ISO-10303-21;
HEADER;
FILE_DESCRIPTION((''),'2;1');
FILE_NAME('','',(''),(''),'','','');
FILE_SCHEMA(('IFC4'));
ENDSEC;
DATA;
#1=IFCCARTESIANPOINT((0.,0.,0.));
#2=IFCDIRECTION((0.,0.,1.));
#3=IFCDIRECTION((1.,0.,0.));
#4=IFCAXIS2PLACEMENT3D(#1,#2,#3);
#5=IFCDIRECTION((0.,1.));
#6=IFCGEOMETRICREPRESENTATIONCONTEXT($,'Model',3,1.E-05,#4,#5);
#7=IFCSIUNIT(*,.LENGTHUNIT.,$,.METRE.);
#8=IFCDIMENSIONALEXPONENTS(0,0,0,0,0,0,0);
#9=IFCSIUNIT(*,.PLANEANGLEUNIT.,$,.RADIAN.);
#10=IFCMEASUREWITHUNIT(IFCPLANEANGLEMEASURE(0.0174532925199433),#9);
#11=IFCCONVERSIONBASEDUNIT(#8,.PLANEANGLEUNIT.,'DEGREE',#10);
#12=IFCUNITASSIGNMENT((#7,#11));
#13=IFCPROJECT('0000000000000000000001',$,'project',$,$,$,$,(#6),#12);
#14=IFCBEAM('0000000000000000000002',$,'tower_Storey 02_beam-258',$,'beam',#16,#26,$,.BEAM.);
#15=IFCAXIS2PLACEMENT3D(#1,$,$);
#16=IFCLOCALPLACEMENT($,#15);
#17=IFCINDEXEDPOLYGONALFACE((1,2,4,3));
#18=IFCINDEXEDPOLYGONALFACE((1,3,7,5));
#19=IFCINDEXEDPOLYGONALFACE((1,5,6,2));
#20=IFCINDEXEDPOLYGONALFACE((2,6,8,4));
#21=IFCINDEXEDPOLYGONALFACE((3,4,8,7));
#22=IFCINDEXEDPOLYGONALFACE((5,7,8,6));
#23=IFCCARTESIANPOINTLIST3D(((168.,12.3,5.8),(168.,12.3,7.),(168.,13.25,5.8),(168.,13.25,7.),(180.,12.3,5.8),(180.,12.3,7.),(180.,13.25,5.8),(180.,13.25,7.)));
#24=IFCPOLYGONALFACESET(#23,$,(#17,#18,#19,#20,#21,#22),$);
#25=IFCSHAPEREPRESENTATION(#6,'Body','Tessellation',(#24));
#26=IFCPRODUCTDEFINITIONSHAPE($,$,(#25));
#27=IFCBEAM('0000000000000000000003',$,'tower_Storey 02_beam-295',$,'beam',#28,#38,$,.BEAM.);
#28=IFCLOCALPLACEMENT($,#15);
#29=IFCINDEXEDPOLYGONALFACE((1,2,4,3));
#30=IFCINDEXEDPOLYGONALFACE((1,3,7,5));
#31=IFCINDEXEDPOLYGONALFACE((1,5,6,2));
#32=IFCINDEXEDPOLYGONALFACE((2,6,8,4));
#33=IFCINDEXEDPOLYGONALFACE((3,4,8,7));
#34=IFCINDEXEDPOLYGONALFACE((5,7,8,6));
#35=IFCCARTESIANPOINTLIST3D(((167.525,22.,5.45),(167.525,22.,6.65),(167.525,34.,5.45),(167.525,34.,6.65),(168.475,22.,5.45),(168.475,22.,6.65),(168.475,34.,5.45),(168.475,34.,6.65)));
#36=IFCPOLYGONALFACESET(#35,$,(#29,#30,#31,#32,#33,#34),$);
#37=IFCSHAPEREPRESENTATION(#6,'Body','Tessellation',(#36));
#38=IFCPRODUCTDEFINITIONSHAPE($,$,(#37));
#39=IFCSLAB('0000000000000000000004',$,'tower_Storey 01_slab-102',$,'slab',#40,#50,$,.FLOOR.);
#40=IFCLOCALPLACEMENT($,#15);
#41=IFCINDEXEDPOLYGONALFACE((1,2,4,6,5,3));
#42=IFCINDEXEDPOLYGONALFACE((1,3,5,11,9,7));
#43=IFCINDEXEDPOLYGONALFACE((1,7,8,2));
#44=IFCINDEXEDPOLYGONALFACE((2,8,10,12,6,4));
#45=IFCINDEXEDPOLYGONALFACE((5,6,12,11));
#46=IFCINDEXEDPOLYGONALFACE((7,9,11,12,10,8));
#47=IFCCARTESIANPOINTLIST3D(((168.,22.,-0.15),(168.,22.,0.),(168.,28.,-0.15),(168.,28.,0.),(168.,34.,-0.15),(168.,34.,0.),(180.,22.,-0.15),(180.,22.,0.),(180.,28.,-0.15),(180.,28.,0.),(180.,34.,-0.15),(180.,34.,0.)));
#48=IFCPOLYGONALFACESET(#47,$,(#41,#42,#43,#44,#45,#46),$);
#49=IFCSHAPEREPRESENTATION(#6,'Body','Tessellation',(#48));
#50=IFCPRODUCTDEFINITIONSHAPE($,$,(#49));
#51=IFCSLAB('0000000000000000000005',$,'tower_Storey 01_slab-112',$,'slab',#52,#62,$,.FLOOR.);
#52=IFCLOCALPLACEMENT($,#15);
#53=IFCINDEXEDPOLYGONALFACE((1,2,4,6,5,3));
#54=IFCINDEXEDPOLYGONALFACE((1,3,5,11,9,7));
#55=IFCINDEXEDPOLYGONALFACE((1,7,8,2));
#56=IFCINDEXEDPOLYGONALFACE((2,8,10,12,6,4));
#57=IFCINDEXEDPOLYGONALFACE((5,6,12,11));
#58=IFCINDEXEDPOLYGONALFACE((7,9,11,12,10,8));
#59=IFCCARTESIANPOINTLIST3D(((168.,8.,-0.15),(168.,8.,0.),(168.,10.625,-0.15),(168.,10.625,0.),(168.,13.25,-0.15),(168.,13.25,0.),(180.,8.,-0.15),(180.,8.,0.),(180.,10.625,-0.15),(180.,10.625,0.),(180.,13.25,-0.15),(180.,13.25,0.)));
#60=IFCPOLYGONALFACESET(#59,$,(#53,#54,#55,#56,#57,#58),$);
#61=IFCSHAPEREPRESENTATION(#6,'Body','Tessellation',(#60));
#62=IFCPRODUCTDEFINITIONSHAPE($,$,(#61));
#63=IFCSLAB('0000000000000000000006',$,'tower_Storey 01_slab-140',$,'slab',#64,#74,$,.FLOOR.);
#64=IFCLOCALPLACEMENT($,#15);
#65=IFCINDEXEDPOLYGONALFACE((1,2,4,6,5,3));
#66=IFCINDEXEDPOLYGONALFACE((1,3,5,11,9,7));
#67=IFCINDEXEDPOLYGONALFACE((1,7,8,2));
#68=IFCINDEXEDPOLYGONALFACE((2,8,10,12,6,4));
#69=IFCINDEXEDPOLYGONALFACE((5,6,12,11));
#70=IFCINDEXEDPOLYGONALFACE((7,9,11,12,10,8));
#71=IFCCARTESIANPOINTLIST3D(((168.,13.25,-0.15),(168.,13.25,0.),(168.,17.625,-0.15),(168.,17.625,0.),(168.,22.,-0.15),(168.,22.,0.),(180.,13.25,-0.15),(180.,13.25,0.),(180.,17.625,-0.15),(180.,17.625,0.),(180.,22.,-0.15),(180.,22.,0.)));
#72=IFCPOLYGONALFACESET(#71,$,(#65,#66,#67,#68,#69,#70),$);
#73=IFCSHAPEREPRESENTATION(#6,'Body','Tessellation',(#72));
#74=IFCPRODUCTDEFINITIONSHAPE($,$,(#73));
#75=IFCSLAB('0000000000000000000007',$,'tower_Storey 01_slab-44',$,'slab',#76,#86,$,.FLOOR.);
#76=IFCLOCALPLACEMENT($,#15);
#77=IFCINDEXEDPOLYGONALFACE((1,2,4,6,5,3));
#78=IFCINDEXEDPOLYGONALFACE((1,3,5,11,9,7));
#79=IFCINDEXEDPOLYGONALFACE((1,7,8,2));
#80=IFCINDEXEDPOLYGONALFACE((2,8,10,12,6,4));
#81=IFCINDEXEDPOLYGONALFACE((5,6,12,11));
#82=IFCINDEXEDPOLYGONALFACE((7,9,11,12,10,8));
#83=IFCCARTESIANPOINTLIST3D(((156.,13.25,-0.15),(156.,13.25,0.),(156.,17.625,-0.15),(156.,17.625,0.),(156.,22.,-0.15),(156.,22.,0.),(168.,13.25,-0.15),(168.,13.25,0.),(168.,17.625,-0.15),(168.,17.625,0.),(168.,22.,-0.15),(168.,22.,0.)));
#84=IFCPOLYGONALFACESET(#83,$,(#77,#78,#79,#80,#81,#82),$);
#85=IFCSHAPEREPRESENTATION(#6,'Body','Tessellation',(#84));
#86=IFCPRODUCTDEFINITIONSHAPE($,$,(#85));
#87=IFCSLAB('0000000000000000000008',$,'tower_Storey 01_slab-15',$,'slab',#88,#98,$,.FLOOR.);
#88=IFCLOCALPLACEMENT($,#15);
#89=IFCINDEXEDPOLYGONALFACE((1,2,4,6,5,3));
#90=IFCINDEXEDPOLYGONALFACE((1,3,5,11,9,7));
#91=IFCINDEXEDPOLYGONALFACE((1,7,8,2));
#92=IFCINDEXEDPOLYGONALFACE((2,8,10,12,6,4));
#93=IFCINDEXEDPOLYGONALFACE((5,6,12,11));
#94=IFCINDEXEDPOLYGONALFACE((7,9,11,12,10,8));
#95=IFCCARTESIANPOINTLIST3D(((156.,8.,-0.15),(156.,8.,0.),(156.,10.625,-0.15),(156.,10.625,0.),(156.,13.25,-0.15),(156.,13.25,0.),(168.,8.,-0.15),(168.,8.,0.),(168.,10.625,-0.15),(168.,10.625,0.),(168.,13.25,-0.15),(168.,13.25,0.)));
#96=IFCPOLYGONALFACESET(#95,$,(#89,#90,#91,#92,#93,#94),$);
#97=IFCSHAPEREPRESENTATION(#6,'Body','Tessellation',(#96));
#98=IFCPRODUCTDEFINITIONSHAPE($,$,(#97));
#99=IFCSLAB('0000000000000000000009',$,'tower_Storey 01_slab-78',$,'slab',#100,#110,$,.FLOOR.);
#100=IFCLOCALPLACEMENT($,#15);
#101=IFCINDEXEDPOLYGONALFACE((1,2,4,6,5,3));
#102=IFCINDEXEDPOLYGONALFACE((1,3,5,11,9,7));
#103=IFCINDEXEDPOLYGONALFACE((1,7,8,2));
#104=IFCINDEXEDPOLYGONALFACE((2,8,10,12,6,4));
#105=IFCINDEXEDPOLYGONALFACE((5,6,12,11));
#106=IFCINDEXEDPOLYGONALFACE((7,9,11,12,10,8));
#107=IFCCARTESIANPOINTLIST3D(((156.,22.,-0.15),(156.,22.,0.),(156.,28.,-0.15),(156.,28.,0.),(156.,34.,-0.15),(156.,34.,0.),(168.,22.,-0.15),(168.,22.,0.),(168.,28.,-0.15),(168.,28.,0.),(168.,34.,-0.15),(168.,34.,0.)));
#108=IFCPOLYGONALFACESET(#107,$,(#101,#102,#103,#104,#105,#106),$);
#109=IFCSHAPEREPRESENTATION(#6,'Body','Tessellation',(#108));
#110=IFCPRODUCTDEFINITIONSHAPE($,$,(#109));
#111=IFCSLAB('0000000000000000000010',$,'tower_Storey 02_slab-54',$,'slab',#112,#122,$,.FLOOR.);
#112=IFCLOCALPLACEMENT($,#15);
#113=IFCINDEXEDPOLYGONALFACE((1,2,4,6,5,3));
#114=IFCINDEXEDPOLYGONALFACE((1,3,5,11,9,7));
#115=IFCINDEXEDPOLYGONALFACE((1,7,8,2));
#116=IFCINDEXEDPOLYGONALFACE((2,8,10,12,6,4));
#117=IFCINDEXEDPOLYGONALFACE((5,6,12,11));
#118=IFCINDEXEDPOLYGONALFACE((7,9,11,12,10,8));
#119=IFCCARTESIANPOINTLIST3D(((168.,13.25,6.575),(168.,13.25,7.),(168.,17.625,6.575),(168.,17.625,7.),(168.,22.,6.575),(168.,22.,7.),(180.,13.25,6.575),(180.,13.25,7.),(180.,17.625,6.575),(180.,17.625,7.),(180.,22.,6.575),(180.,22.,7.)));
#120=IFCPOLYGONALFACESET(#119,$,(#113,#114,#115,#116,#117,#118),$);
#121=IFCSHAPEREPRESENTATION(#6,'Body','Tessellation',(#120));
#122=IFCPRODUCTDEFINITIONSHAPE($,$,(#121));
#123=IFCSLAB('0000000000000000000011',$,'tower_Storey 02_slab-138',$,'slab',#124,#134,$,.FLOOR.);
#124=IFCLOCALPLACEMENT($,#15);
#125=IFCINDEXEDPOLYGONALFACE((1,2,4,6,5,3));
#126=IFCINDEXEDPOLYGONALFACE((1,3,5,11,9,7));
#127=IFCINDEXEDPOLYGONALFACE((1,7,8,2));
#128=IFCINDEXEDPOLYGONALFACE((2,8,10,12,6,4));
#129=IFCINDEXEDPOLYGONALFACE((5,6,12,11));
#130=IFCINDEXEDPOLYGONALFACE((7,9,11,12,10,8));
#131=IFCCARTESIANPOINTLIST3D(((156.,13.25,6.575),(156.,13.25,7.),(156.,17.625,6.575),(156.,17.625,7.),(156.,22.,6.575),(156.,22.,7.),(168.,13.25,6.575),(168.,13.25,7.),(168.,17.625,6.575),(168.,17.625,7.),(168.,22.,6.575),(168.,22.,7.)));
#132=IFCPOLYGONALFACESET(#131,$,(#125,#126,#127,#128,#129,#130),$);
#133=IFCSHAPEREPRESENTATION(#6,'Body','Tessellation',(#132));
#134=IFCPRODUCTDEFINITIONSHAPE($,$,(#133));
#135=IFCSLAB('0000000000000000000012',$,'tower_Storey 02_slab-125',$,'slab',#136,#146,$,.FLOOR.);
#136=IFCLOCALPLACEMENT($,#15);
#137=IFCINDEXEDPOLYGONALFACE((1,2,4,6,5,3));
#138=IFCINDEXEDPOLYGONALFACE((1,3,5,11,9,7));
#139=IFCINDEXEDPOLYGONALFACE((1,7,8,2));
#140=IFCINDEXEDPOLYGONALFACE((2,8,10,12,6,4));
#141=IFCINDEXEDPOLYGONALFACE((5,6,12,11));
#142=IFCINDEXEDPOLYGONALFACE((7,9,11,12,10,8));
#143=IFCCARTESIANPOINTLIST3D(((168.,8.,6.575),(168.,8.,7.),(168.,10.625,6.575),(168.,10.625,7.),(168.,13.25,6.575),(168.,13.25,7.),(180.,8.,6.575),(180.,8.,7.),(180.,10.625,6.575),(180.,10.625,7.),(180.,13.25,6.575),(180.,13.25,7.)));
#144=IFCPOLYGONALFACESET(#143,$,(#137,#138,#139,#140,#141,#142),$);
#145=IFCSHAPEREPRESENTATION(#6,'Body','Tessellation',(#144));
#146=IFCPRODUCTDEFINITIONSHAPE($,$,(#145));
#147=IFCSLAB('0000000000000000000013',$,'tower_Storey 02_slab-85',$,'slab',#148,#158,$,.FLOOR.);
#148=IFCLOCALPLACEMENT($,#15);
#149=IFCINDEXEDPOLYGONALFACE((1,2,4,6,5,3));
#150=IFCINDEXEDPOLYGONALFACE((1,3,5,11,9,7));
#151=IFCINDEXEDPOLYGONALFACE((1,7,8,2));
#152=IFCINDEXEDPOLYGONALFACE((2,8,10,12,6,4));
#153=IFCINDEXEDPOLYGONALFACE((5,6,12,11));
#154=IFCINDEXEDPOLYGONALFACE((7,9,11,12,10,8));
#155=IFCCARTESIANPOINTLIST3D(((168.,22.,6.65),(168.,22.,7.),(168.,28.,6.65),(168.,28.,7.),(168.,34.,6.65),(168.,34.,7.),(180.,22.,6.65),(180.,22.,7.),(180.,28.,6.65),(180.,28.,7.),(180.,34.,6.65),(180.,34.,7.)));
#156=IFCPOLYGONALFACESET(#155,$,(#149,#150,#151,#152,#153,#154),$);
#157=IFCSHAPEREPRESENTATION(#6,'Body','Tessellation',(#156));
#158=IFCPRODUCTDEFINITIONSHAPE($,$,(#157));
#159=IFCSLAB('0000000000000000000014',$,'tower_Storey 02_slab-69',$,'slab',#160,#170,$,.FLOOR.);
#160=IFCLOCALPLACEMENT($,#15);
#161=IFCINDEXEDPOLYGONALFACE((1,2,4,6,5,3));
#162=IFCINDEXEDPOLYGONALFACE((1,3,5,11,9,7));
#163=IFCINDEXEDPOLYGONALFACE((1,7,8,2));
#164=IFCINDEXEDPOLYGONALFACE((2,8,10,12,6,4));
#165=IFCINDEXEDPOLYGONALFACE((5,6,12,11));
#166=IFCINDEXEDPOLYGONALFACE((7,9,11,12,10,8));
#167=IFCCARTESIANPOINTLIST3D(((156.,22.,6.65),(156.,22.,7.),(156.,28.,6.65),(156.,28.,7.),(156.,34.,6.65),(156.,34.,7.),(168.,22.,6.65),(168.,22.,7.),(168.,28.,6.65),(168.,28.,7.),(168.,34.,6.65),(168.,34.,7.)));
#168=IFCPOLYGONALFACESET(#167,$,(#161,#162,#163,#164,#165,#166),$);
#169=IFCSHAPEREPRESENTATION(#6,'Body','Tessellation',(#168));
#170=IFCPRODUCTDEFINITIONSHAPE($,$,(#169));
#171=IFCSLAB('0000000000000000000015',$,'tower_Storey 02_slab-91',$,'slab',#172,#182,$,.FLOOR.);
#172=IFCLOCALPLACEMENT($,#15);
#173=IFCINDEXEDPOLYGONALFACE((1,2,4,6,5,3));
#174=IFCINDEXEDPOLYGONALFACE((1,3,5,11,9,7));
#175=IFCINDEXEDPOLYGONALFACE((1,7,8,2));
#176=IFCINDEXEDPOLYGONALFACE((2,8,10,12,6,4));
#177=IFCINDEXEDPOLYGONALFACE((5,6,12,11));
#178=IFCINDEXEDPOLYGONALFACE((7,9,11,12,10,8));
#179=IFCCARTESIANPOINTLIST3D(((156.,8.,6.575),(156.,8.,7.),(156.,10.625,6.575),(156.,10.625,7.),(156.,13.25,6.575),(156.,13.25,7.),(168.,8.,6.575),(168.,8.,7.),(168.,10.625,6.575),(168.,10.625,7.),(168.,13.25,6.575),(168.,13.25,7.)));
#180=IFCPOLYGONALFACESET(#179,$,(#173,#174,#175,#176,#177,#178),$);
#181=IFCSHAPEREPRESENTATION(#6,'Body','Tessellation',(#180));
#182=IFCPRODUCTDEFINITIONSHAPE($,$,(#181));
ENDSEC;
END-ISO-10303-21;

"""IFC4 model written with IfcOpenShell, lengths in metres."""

from ifc_helpers import new_model, entity, si_unit, converted_unit, direction, frame, origin_with_axes, place, context, project, polyline, outline, extrude, element, save


model = new_model("IFC4")

# Units and contexts
model_context = context("Model", 3, precision=1e-05, world=origin_with_axes(), true_north=direction((0.0, 1.0)))
ifc_project = project(units=[si_unit("LENGTHUNIT", "METRE"), converted_unit("PLANEANGLEUNIT", "DEGREE", entity("IfcPlaneAngleMeasure", 0.0174532925199433), si_unit("PLANEANGLEUNIT", "RADIAN"), dimensions=[0, 0, 0, 0, 0, 0, 0])], contexts=[model_context])

# Shared definitions
placement_1 = place(None, origin_with_axes())
placement_2 = place(placement_1, origin_with_axes())

# Shared definitions
placement_3 = place(placement_1, frame((0.0, 0.0, 7.0), z_axis=(0.0, 0.0, 1.0), x_axis=(1.0, 0.0, 0.0)))

# Beams
for number, where, z_axis, x_axis, name in (
    (1, (168.0, 12.775, -0.6), (1.0, 0.0, 0.0), (0.0, 1.0, 0.0), "tower_Storey 02_beam-258"),
    (2, (168.0, 22.0, -0.95), (0.0, 1.0, 0.0), (-1.0, 0.0, 0.0), "tower_Storey 02_beam-295"),
):
    element("IfcBeam", number, at=place(placement_3, frame(where, z_axis=z_axis, x_axis=x_axis)), Name=name, ObjectType="beam", PredefinedType="BEAM", context=model_context, body=[
        extrude(outline(polyline([(0.475, 0.6, 0.0), (-0.475, 0.6, 0.0), (-0.475, -0.6, 0.0), (0.475, -0.6, 0.0), (0.475, 0.6, 0.0)])), origin_with_axes(), (0.0, 0.0, 1.0), 12.0),
    ])

# Slabs
slab_1_placement = place(placement_2, frame((174.0, 28.0, -0.15), z_axis=(0.0, 0.0, 1.0), x_axis=(1.0, 0.0, 0.0)))
element("IfcSlab", 3, at=slab_1_placement, Name="tower_Storey 01_slab-102", ObjectType="slab", PredefinedType="FLOOR", context=model_context, body=[
    extrude(outline(polyline([(-6.0, -6.0, 0.0), (6.0, -6.0, 0.0), (6.0, 0.0, 0.0), (6.0, 6.0, 0.0), (-6.0, 6.0, 0.0), (-6.0, 0.0, 0.0), (-6.0, -6.0, 0.0)])), origin_with_axes(), (0.0, 0.0, 1.0), 0.15),
])
slab_2_placement = place(placement_2, frame((174.0, 10.625, -0.15), z_axis=(0.0, 0.0, 1.0), x_axis=(1.0, 0.0, 0.0)))
element("IfcSlab", 4, at=slab_2_placement, Name="tower_Storey 01_slab-112", ObjectType="slab", PredefinedType="FLOOR", context=model_context, body=[
    extrude(outline(polyline([(-6.0, -2.625, 0.0), (6.0, -2.625, 0.0), (6.0, 0.0, 0.0), (6.0, 2.625, 0.0), (-6.0, 2.625, 0.0), (-6.0, 0.0, 0.0), (-6.0, -2.625, 0.0)])), origin_with_axes(), (0.0, 0.0, 1.0), 0.15),
])
for number, where, z_axis, x_axis, name in (
    (5, (174.0, 17.625, -0.15), (0.0, 0.0, 1.0), (1.0, 0.0, 0.0), "tower_Storey 01_slab-140"),
    (6, (162.0, 17.625, -0.15), (0.0, 0.0, 1.0), (1.0, 0.0, 0.0), "tower_Storey 01_slab-44"),
):
    element("IfcSlab", number, at=place(placement_2, frame(where, z_axis=z_axis, x_axis=x_axis)), Name=name, ObjectType="slab", PredefinedType="FLOOR", context=model_context, body=[
        extrude(outline(polyline([(-6.0, 0.0, 0.0), (-6.0, -4.375, 0.0), (6.0, -4.375, 0.0), (6.0, 0.0, 0.0), (6.0, 4.375, 0.0), (-6.0, 4.375, 0.0), (-6.0, 0.0, 0.0)])), origin_with_axes(), (0.0, 0.0, 1.0), 0.15),
    ])
slab_3_placement = place(placement_2, frame((162.0, 10.625, -0.15), z_axis=(0.0, 0.0, 1.0), x_axis=(1.0, 0.0, 0.0)))
element("IfcSlab", 7, at=slab_3_placement, Name="tower_Storey 01_slab-15", ObjectType="slab", PredefinedType="FLOOR", context=model_context, body=[
    extrude(outline(polyline([(-6.0, -2.625, 0.0), (6.0, -2.625, 0.0), (6.0, 0.0, 0.0), (6.0, 2.625, 0.0), (-6.0, 2.625, 0.0), (-6.0, 0.0, 0.0), (-6.0, -2.625, 0.0)])), origin_with_axes(), (0.0, 0.0, 1.0), 0.15),
])
slab_4_placement = place(placement_2, frame((162.0, 28.0, -0.15), z_axis=(0.0, 0.0, 1.0), x_axis=(1.0, 0.0, 0.0)))
element("IfcSlab", 8, at=slab_4_placement, Name="tower_Storey 01_slab-78", ObjectType="slab", PredefinedType="FLOOR", context=model_context, body=[
    extrude(outline(polyline([(-6.0, -6.0, 0.0), (6.0, -6.0, 0.0), (6.0, 0.0, 0.0), (6.0, 6.0, 0.0), (-6.0, 6.0, 0.0), (-6.0, 0.0, 0.0), (-6.0, -6.0, 0.0)])), origin_with_axes(), (0.0, 0.0, 1.0), 0.15),
])
for number, where, z_axis, x_axis, name in (
    (9, (174.0, 17.625, -0.425), (0.0, 0.0, 1.0), (1.0, 0.0, 0.0), "tower_Storey 02_slab-54"),
    (10, (162.0, 17.625, -0.425), (0.0, 0.0, 1.0), (1.0, 0.0, 0.0), "tower_Storey 02_slab-138"),
):
    element("IfcSlab", number, at=place(placement_3, frame(where, z_axis=z_axis, x_axis=x_axis)), Name=name, ObjectType="slab", PredefinedType="FLOOR", context=model_context, body=[
        extrude(outline(polyline([(-6.0, 0.0, 0.0), (-6.0, -4.375, 0.0), (6.0, -4.375, 0.0), (6.0, 0.0, 0.0), (6.0, 4.375, 0.0), (-6.0, 4.375, 0.0), (-6.0, 0.0, 0.0)])), origin_with_axes(), (0.0, 0.0, 1.0), 0.425),
    ])
slab_5_placement = place(placement_3, frame((174.0, 10.625, -0.425), z_axis=(0.0, 0.0, 1.0), x_axis=(1.0, 0.0, 0.0)))
element("IfcSlab", 11, at=slab_5_placement, Name="tower_Storey 02_slab-125", ObjectType="slab", PredefinedType="FLOOR", context=model_context, body=[
    extrude(outline(polyline([(-6.0, -2.625, 0.0), (6.0, -2.625, 0.0), (6.0, 0.0, 0.0), (6.0, 2.625, 0.0), (-6.0, 2.625, 0.0), (-6.0, 0.0, 0.0), (-6.0, -2.625, 0.0)])), origin_with_axes(), (0.0, 0.0, 1.0), 0.425),
])
for number, where, z_axis, x_axis, name in (
    (12, (174.0, 28.0, -0.35), (0.0, 0.0, 1.0), (1.0, 0.0, 0.0), "tower_Storey 02_slab-85"),
    (13, (162.0, 28.0, -0.35), (0.0, 0.0, 1.0), (1.0, 0.0, 0.0), "tower_Storey 02_slab-69"),
):
    element("IfcSlab", number, at=place(placement_3, frame(where, z_axis=z_axis, x_axis=x_axis)), Name=name, ObjectType="slab", PredefinedType="FLOOR", context=model_context, body=[
        extrude(outline(polyline([(-6.0, -6.0, 0.0), (6.0, -6.0, 0.0), (6.0, 0.0, 0.0), (6.0, 6.0, 0.0), (-6.0, 6.0, 0.0), (-6.0, 0.0, 0.0), (-6.0, -6.0, 0.0)])), origin_with_axes(), (0.0, 0.0, 1.0), 0.35),
    ])
slab_6_placement = place(placement_3, frame((162.0, 10.625, -0.425), z_axis=(0.0, 0.0, 1.0), x_axis=(1.0, 0.0, 0.0)))
element("IfcSlab", 14, at=slab_6_placement, Name="tower_Storey 02_slab-91", ObjectType="slab", PredefinedType="FLOOR", context=model_context, body=[
    extrude(outline(polyline([(-6.0, -2.625, 0.0), (6.0, -2.625, 0.0), (6.0, 0.0, 0.0), (6.0, 2.625, 0.0), (-6.0, 2.625, 0.0), (-6.0, 0.0, 0.0), (-6.0, -2.625, 0.0)])), origin_with_axes(), (0.0, 0.0, 1.0), 0.425),
])

save(model, "model.ifc")
